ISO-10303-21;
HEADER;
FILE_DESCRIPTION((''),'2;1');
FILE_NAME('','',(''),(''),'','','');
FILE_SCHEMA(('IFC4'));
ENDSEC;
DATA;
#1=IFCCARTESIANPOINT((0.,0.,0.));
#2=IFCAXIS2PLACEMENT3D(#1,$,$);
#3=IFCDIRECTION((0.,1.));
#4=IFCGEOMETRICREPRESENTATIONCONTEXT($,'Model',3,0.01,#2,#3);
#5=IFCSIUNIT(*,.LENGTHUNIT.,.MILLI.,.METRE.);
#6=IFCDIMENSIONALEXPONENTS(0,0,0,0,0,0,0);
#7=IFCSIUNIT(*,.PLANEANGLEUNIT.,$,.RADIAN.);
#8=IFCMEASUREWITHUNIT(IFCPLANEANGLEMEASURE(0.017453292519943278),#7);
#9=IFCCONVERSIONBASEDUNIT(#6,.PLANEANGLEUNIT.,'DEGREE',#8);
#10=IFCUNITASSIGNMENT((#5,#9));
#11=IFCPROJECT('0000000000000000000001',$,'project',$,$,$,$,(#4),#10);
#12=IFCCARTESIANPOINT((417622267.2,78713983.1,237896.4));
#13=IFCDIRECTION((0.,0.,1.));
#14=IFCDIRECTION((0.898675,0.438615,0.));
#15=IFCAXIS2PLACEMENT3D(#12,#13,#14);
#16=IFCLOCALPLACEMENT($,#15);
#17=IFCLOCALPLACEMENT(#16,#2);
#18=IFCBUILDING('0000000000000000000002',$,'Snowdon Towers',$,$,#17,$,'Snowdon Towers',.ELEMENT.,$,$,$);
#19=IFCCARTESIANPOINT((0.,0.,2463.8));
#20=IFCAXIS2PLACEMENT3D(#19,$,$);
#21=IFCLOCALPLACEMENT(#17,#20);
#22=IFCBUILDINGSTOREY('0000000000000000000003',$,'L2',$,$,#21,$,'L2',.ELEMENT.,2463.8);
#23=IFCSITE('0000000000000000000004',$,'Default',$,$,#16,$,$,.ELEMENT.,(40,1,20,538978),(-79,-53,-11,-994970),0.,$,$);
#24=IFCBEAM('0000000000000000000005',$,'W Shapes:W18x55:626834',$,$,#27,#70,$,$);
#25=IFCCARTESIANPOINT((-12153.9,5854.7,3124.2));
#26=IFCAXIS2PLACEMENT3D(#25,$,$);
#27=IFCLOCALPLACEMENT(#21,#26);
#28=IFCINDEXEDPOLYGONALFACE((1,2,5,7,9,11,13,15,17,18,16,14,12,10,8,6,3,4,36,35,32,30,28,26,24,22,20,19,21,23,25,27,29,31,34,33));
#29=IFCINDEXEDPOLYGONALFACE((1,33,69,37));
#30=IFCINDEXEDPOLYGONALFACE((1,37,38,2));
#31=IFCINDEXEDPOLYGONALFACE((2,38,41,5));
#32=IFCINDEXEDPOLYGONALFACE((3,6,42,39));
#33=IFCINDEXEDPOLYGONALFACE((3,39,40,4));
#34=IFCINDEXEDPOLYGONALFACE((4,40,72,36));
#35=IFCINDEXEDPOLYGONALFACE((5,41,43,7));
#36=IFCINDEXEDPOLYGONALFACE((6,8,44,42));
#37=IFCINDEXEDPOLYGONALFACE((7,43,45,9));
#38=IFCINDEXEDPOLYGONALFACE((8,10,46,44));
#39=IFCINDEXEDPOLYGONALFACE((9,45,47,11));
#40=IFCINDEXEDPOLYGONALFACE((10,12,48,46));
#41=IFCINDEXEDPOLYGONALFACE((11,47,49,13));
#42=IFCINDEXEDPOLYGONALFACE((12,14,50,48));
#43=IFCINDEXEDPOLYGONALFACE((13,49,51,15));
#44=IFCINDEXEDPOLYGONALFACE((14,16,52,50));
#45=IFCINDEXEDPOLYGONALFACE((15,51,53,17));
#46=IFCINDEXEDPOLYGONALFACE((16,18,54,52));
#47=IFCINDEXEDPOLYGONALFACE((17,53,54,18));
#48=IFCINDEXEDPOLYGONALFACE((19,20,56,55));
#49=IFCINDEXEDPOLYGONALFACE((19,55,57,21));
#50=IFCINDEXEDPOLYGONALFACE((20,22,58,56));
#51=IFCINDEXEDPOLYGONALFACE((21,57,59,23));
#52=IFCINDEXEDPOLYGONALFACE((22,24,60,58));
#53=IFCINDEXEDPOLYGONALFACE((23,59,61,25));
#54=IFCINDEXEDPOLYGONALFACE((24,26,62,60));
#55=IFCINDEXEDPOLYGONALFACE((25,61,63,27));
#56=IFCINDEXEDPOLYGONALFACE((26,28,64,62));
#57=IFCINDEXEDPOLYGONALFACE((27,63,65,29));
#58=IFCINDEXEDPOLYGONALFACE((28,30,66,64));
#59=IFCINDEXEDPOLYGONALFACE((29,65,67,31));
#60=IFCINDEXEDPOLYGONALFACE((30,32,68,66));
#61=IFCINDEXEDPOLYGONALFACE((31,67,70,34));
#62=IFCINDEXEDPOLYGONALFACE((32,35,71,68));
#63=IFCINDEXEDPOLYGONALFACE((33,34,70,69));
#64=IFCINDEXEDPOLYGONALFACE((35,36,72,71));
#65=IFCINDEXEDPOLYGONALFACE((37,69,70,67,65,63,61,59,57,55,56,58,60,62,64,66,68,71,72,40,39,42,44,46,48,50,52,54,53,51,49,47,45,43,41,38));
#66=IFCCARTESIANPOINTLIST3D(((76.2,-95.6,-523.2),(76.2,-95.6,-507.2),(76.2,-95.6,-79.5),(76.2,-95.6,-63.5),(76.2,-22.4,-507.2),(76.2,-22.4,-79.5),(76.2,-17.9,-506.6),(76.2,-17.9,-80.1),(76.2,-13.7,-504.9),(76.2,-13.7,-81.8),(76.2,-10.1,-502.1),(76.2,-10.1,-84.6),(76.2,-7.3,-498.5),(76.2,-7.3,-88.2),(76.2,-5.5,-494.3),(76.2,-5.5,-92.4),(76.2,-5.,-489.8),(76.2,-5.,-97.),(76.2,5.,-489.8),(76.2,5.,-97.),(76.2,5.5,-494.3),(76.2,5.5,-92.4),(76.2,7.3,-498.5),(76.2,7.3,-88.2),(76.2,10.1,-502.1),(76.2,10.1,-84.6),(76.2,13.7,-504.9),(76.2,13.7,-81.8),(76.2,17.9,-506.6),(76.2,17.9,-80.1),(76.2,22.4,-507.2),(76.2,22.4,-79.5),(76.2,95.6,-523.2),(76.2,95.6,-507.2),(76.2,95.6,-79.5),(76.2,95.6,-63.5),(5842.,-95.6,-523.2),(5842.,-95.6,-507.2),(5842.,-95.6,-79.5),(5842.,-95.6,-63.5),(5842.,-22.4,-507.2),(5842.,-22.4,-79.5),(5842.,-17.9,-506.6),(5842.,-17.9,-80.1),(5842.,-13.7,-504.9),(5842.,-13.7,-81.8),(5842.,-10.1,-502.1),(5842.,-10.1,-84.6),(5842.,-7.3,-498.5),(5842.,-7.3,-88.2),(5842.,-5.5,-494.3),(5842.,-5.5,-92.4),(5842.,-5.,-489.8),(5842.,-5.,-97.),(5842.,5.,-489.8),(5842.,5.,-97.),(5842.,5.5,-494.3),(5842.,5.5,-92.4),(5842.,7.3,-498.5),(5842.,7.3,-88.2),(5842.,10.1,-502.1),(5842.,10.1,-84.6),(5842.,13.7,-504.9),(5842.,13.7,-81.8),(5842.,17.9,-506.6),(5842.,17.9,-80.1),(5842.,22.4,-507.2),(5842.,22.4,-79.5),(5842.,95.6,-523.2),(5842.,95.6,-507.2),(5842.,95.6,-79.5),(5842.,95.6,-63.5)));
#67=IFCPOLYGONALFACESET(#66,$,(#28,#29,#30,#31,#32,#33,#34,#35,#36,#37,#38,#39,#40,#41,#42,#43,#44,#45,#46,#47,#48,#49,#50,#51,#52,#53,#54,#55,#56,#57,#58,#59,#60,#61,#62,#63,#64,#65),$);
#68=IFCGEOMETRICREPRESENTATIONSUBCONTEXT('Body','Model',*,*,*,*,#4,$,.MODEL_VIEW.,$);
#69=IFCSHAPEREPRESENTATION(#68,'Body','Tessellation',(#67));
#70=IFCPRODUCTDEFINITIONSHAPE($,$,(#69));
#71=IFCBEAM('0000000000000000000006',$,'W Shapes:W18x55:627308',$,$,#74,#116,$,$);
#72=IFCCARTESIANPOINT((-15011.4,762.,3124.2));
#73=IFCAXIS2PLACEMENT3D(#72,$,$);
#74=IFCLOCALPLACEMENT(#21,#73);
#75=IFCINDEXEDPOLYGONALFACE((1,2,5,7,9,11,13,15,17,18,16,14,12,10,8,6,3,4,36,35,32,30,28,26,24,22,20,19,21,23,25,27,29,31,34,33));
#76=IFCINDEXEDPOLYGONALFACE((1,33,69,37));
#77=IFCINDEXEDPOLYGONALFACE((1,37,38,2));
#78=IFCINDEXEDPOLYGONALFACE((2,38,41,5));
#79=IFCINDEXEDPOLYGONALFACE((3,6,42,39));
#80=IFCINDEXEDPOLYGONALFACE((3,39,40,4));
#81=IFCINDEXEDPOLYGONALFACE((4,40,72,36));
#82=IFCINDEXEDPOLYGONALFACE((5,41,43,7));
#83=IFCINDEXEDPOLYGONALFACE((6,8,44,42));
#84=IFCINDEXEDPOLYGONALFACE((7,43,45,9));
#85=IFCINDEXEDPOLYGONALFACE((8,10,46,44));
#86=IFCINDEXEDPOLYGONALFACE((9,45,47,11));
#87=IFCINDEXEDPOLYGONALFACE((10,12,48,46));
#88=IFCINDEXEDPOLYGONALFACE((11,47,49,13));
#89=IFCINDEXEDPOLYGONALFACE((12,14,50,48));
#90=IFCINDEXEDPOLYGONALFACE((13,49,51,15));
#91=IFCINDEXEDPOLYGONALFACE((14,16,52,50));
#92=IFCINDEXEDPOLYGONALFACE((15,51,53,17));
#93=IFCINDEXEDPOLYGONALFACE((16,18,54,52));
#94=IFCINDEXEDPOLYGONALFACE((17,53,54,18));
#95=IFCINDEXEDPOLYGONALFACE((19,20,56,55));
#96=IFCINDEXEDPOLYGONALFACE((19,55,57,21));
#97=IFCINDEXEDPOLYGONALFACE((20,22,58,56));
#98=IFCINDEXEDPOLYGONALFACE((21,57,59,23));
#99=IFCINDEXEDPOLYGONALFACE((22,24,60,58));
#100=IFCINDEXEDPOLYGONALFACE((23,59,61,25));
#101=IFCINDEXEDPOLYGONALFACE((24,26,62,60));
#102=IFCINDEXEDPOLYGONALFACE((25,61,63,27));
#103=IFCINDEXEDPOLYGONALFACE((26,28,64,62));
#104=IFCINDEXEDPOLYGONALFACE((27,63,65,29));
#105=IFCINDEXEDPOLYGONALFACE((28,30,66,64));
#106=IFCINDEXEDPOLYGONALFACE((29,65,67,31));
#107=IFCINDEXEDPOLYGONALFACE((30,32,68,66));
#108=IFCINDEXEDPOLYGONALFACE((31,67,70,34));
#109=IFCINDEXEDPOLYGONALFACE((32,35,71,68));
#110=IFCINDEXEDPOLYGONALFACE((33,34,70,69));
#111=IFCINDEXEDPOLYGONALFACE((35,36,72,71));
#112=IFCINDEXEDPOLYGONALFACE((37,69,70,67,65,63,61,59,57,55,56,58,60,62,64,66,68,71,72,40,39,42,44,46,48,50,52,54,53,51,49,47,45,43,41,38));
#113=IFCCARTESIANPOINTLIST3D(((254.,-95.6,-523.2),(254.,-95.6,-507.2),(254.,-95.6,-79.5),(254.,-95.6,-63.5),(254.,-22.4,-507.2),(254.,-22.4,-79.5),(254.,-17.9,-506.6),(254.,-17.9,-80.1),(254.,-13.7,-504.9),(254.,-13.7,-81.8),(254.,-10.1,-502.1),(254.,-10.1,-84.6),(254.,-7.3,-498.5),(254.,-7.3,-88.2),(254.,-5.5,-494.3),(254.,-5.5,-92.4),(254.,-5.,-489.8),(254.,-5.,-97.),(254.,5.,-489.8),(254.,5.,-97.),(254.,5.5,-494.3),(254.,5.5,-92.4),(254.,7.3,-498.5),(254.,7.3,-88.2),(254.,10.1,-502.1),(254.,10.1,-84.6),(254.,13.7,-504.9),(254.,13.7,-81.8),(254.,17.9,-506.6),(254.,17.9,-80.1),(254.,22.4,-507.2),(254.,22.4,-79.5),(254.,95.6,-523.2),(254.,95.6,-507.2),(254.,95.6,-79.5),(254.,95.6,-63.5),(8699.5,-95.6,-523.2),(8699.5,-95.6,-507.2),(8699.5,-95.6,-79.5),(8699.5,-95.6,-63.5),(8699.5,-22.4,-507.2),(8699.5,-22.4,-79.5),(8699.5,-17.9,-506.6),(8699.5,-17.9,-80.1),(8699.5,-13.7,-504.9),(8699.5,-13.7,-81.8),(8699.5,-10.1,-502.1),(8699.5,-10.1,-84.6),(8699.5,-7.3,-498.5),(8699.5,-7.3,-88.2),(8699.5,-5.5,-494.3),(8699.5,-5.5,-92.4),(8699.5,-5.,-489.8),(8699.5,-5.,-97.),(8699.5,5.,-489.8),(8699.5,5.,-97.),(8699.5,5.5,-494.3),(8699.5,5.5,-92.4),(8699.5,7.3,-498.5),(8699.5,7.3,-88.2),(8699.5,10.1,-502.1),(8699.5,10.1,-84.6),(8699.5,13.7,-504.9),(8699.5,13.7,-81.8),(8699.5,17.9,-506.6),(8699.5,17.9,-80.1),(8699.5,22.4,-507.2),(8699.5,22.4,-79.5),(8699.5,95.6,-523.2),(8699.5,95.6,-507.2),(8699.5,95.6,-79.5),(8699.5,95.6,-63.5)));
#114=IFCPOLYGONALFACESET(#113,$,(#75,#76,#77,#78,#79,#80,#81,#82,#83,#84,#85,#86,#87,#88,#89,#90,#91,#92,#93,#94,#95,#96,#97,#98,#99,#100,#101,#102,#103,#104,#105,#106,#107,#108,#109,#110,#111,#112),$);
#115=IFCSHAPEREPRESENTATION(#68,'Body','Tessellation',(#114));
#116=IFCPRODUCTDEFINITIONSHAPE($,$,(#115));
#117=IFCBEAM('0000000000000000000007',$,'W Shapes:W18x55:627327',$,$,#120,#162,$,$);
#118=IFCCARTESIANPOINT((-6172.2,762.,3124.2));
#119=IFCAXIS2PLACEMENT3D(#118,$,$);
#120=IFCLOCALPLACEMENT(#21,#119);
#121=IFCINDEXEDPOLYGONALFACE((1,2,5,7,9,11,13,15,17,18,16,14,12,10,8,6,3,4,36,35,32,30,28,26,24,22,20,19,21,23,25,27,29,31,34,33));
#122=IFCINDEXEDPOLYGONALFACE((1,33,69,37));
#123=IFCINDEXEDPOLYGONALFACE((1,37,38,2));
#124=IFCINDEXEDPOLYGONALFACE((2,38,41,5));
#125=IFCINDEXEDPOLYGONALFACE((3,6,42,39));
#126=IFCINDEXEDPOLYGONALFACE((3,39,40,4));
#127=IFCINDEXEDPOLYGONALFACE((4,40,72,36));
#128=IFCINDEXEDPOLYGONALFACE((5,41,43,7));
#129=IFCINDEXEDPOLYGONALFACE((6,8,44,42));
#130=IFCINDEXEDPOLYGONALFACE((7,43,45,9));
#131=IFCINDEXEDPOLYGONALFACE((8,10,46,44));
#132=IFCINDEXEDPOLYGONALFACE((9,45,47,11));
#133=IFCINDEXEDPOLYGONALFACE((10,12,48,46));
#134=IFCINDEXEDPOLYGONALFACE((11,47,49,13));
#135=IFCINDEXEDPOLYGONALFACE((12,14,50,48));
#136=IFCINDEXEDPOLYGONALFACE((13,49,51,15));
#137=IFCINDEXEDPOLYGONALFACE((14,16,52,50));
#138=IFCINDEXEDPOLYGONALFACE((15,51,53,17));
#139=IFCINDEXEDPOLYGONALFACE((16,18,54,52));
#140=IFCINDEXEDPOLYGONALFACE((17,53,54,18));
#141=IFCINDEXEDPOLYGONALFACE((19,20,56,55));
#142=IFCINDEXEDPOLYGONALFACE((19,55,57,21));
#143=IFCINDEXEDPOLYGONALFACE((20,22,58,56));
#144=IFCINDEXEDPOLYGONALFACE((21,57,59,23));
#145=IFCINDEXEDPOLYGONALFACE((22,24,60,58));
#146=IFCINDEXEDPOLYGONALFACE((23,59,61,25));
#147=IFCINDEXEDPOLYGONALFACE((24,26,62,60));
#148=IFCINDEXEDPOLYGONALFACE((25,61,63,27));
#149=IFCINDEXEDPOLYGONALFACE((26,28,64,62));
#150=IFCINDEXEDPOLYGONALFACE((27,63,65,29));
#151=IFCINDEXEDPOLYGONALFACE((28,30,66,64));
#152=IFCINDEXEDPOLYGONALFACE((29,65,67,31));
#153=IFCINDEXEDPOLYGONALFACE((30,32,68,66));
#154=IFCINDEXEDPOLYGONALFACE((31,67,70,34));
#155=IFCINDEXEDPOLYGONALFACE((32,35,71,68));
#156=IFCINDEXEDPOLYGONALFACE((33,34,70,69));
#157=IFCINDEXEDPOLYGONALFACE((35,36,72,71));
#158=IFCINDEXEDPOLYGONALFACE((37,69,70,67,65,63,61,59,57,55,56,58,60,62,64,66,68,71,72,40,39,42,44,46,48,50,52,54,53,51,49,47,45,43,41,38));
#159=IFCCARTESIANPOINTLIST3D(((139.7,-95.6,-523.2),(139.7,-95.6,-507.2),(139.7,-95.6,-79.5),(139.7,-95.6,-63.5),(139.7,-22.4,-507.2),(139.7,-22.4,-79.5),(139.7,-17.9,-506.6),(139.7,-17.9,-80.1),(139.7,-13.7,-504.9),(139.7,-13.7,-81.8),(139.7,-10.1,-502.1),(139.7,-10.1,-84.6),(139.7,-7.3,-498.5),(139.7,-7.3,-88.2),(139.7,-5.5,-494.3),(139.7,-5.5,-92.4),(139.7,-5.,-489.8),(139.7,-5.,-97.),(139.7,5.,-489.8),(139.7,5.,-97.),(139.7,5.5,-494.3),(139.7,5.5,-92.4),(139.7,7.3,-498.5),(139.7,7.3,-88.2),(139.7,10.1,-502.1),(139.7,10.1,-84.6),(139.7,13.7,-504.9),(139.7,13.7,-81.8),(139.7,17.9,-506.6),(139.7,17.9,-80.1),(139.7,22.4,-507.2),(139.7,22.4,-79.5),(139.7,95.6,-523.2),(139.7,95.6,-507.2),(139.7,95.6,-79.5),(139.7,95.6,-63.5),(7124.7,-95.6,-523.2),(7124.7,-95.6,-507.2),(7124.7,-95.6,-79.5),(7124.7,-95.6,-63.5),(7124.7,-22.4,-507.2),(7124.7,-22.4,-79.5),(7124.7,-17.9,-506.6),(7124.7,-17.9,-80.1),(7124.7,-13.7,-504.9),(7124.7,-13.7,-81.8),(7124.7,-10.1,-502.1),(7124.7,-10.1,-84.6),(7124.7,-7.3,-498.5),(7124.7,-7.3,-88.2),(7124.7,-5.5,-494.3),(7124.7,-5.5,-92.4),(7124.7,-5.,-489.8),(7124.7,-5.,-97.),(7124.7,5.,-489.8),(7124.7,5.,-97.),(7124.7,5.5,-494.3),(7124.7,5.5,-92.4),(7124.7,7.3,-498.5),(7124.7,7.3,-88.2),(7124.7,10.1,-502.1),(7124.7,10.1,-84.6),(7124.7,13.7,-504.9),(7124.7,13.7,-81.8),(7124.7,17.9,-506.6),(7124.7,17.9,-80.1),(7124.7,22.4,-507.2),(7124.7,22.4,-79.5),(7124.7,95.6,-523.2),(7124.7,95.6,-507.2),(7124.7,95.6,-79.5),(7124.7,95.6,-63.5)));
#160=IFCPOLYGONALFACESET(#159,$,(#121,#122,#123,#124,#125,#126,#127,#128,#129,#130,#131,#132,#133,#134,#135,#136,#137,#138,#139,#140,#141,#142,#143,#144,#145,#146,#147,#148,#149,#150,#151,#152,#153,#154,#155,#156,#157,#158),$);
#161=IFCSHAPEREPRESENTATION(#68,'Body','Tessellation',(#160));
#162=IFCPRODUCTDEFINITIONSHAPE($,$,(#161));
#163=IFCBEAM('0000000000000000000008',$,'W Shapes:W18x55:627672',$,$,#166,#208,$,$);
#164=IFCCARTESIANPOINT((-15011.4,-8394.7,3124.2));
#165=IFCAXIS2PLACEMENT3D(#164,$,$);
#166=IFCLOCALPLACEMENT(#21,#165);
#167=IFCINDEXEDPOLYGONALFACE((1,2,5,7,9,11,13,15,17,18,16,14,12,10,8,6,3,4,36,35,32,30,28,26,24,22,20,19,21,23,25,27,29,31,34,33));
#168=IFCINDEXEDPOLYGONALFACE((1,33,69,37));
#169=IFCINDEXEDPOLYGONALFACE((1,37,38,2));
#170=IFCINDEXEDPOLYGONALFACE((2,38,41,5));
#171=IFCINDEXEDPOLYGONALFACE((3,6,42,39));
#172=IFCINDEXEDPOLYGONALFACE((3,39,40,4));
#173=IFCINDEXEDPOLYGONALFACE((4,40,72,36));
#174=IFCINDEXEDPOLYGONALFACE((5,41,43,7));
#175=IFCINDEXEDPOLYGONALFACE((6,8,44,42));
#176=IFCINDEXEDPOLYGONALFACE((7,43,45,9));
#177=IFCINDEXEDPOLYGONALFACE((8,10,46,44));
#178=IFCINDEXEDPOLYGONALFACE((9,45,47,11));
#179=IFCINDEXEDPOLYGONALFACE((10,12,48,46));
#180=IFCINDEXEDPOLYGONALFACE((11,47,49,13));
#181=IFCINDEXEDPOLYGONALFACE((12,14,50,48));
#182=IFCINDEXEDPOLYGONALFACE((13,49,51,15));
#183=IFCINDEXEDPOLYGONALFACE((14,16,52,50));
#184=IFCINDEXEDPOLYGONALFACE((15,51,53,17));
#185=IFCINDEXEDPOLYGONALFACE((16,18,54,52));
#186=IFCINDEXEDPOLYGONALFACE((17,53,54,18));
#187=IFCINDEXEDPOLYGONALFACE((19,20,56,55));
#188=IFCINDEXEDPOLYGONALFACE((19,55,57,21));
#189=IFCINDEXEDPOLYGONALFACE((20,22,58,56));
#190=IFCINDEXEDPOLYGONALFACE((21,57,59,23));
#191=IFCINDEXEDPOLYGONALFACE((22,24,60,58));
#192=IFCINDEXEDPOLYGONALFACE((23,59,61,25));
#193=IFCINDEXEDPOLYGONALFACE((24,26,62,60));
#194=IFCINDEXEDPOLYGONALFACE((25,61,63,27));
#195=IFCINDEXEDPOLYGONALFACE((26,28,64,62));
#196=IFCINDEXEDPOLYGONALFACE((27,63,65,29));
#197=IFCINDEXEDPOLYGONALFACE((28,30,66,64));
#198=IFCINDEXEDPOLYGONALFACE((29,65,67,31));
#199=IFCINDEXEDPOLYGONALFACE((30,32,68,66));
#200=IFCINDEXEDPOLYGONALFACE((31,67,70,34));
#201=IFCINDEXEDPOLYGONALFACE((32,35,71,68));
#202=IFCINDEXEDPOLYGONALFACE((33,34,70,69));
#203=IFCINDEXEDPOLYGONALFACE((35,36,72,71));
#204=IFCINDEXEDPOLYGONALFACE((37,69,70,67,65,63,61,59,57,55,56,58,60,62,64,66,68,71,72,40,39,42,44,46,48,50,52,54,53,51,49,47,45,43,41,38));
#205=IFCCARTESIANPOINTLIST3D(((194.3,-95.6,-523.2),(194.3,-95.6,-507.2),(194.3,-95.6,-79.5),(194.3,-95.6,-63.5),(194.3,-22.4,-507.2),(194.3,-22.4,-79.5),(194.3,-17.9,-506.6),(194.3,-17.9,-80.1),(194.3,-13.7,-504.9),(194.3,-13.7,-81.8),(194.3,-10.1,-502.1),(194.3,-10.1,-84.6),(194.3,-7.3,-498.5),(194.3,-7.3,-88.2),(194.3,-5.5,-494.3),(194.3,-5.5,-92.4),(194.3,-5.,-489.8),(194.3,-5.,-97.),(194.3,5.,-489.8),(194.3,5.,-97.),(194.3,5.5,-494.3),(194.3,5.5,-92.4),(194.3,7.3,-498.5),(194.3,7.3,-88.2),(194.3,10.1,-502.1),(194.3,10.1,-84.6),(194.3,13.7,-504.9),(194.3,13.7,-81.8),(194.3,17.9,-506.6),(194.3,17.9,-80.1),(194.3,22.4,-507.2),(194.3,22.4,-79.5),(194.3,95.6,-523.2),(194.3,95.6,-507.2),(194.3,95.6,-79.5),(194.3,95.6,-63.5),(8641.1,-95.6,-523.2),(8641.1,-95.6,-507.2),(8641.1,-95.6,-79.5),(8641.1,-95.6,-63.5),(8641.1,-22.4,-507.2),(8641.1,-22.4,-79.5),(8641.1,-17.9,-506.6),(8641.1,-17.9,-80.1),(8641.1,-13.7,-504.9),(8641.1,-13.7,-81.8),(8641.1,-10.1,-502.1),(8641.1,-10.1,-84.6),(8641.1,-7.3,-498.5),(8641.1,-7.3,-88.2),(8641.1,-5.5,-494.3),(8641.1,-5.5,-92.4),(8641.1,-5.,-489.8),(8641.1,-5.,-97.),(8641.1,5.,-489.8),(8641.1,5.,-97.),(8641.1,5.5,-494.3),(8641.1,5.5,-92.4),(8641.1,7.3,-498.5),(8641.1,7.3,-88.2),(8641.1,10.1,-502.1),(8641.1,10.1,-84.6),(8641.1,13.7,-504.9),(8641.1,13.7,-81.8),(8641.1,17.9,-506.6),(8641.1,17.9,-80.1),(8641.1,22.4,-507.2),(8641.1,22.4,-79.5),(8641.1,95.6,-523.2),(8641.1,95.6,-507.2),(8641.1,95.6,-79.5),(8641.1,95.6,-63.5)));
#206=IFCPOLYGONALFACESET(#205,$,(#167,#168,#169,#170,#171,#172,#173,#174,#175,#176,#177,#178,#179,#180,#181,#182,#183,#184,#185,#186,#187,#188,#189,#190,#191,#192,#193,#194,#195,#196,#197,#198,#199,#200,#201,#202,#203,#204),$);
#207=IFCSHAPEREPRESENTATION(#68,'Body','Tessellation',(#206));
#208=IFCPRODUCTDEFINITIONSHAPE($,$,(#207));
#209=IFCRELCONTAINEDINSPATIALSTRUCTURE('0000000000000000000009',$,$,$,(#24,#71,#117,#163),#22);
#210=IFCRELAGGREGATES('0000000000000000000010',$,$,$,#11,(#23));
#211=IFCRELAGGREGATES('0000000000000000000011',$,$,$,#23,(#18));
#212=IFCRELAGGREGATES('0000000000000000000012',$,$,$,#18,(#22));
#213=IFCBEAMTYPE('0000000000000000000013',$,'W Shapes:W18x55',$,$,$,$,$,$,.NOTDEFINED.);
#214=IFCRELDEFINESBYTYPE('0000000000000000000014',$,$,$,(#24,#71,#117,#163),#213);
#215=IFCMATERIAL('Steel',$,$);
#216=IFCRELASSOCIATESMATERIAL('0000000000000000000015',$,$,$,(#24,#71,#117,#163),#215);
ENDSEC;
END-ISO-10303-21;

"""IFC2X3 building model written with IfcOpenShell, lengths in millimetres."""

from ifc_helpers import new_model, entity, si_unit, converted_unit, direction, frame, frame_2d, origin, place, context, subcontext, project, spatial, i_section, extrude, material, type_object, element, save


model = new_model("IFC2X3")

# Units and contexts
model_context = context("Model", 3, precision=0.01, world=origin(), true_north=direction((0.0, 1.0)))
body_context = subcontext(model_context, "Body", "Model", "MODEL_VIEW")
ifc_project = project(units=[si_unit("LENGTHUNIT", "METRE", prefix="MILLI"), converted_unit("PLANEANGLEUNIT", "DEGREE", entity("IfcPlaneAngleMeasure", 0.017453292519943278), si_unit("PLANEANGLEUNIT", "RADIAN"), dimensions=[0, 0, 0, 0, 0, 0, 0])], contexts=[model_context])

# Site, building, storey
site_placement = place(None, frame((417622267.2, 78713983.1, 237896.4), z_axis=(0.0, 0.0, 1.0), x_axis=(0.898675, 0.438615, 0.0)))
site = spatial("IfcSite", under=ifc_project, at=site_placement, Name="Default", CompositionType="ELEMENT", RefLatitude=(40, 1, 20, 538978), RefLongitude=(-79, -53, -11, -994970), RefElevation=0.0)
building_placement = place(site_placement, origin())
building = spatial("IfcBuilding", under=site, at=building_placement, Name="Snowdon Towers", LongName="Snowdon Towers", CompositionType="ELEMENT")
storey_placement = place(building_placement, frame((0.0, 0.0, 2463.8)))
storey = spatial("IfcBuildingStorey", under=building, at=storey_placement, Name="L2", LongName="L2", CompositionType="ELEMENT", Elevation=2463.8)

# Beams
ifc_material_1 = material(Name="Steel")
beam_type_1 = type_object("IfcBeamType", Name="W Shapes:W18x55", PredefinedType="NOTDEFINED")
beam_1_placement = place(storey_placement, frame((-12153.9, 5854.7, 3124.2)))
element("IfcBeam", 1, at=beam_1_placement, inside=storey, type_object=beam_type_1, material=ifc_material_1, Name="W Shapes:W18x55:626834", context=body_context, shape_type="SweptSolid", body=[
    extrude(i_section(OverallWidth=191.3, OverallDepth=459.7, WebThickness=9.9, FlangeThickness=16.0, FilletRadius=17.5, at=frame_2d((0.0, 0.0), x_axis=(0.0, 1.0))), frame((76.2, 0.0, -293.4), z_axis=(1.0, 0.0, 0.0), x_axis=(0.0, 0.0, -1.0)), (0.0, 0.0, 1.0), 5765.8),
])
beam_2_placement = place(storey_placement, frame((-15011.4, 762.0, 3124.2)))
element("IfcBeam", 2, at=beam_2_placement, inside=storey, type_object=beam_type_1, material=ifc_material_1, Name="W Shapes:W18x55:627308", context=body_context, shape_type="SweptSolid", body=[
    extrude(i_section(OverallWidth=191.3, OverallDepth=459.7, WebThickness=9.9, FlangeThickness=16.0, FilletRadius=17.5, at=frame_2d((0.0, 0.0), x_axis=(0.0, 1.0))), frame((254.0, 0.0, -293.4), z_axis=(1.0, 0.0, 0.0), x_axis=(0.0, 0.0, -1.0)), (0.0, 0.0, 1.0), 8445.5),
])
beam_3_placement = place(storey_placement, frame((-6172.2, 762.0, 3124.2)))
element("IfcBeam", 3, at=beam_3_placement, inside=storey, type_object=beam_type_1, material=ifc_material_1, Name="W Shapes:W18x55:627327", context=body_context, shape_type="SweptSolid", body=[
    extrude(i_section(OverallWidth=191.3, OverallDepth=459.7, WebThickness=9.9, FlangeThickness=16.0, FilletRadius=17.5, at=frame_2d((0.0, 0.0), x_axis=(0.0, 1.0))), frame((139.7, 0.0, -293.4), z_axis=(1.0, 0.0, 0.0), x_axis=(0.0, 0.0, -1.0)), (0.0, 0.0, 1.0), 6985.0),
])
beam_4_placement = place(storey_placement, frame((-15011.4, -8394.7, 3124.2)))
element("IfcBeam", 4, at=beam_4_placement, inside=storey, type_object=beam_type_1, material=ifc_material_1, Name="W Shapes:W18x55:627672", context=body_context, shape_type="SweptSolid", body=[
    extrude(i_section(OverallWidth=191.3, OverallDepth=459.7, WebThickness=9.9, FlangeThickness=16.0, FilletRadius=17.5, at=frame_2d((0.0, 0.0), x_axis=(0.0, 1.0))), frame((194.3, 0.0, -293.4), z_axis=(1.0, 0.0, 0.0), x_axis=(0.0, 0.0, -1.0)), (0.0, 0.0, 1.0), 8446.8),
])

save(model, "model.ifc")
